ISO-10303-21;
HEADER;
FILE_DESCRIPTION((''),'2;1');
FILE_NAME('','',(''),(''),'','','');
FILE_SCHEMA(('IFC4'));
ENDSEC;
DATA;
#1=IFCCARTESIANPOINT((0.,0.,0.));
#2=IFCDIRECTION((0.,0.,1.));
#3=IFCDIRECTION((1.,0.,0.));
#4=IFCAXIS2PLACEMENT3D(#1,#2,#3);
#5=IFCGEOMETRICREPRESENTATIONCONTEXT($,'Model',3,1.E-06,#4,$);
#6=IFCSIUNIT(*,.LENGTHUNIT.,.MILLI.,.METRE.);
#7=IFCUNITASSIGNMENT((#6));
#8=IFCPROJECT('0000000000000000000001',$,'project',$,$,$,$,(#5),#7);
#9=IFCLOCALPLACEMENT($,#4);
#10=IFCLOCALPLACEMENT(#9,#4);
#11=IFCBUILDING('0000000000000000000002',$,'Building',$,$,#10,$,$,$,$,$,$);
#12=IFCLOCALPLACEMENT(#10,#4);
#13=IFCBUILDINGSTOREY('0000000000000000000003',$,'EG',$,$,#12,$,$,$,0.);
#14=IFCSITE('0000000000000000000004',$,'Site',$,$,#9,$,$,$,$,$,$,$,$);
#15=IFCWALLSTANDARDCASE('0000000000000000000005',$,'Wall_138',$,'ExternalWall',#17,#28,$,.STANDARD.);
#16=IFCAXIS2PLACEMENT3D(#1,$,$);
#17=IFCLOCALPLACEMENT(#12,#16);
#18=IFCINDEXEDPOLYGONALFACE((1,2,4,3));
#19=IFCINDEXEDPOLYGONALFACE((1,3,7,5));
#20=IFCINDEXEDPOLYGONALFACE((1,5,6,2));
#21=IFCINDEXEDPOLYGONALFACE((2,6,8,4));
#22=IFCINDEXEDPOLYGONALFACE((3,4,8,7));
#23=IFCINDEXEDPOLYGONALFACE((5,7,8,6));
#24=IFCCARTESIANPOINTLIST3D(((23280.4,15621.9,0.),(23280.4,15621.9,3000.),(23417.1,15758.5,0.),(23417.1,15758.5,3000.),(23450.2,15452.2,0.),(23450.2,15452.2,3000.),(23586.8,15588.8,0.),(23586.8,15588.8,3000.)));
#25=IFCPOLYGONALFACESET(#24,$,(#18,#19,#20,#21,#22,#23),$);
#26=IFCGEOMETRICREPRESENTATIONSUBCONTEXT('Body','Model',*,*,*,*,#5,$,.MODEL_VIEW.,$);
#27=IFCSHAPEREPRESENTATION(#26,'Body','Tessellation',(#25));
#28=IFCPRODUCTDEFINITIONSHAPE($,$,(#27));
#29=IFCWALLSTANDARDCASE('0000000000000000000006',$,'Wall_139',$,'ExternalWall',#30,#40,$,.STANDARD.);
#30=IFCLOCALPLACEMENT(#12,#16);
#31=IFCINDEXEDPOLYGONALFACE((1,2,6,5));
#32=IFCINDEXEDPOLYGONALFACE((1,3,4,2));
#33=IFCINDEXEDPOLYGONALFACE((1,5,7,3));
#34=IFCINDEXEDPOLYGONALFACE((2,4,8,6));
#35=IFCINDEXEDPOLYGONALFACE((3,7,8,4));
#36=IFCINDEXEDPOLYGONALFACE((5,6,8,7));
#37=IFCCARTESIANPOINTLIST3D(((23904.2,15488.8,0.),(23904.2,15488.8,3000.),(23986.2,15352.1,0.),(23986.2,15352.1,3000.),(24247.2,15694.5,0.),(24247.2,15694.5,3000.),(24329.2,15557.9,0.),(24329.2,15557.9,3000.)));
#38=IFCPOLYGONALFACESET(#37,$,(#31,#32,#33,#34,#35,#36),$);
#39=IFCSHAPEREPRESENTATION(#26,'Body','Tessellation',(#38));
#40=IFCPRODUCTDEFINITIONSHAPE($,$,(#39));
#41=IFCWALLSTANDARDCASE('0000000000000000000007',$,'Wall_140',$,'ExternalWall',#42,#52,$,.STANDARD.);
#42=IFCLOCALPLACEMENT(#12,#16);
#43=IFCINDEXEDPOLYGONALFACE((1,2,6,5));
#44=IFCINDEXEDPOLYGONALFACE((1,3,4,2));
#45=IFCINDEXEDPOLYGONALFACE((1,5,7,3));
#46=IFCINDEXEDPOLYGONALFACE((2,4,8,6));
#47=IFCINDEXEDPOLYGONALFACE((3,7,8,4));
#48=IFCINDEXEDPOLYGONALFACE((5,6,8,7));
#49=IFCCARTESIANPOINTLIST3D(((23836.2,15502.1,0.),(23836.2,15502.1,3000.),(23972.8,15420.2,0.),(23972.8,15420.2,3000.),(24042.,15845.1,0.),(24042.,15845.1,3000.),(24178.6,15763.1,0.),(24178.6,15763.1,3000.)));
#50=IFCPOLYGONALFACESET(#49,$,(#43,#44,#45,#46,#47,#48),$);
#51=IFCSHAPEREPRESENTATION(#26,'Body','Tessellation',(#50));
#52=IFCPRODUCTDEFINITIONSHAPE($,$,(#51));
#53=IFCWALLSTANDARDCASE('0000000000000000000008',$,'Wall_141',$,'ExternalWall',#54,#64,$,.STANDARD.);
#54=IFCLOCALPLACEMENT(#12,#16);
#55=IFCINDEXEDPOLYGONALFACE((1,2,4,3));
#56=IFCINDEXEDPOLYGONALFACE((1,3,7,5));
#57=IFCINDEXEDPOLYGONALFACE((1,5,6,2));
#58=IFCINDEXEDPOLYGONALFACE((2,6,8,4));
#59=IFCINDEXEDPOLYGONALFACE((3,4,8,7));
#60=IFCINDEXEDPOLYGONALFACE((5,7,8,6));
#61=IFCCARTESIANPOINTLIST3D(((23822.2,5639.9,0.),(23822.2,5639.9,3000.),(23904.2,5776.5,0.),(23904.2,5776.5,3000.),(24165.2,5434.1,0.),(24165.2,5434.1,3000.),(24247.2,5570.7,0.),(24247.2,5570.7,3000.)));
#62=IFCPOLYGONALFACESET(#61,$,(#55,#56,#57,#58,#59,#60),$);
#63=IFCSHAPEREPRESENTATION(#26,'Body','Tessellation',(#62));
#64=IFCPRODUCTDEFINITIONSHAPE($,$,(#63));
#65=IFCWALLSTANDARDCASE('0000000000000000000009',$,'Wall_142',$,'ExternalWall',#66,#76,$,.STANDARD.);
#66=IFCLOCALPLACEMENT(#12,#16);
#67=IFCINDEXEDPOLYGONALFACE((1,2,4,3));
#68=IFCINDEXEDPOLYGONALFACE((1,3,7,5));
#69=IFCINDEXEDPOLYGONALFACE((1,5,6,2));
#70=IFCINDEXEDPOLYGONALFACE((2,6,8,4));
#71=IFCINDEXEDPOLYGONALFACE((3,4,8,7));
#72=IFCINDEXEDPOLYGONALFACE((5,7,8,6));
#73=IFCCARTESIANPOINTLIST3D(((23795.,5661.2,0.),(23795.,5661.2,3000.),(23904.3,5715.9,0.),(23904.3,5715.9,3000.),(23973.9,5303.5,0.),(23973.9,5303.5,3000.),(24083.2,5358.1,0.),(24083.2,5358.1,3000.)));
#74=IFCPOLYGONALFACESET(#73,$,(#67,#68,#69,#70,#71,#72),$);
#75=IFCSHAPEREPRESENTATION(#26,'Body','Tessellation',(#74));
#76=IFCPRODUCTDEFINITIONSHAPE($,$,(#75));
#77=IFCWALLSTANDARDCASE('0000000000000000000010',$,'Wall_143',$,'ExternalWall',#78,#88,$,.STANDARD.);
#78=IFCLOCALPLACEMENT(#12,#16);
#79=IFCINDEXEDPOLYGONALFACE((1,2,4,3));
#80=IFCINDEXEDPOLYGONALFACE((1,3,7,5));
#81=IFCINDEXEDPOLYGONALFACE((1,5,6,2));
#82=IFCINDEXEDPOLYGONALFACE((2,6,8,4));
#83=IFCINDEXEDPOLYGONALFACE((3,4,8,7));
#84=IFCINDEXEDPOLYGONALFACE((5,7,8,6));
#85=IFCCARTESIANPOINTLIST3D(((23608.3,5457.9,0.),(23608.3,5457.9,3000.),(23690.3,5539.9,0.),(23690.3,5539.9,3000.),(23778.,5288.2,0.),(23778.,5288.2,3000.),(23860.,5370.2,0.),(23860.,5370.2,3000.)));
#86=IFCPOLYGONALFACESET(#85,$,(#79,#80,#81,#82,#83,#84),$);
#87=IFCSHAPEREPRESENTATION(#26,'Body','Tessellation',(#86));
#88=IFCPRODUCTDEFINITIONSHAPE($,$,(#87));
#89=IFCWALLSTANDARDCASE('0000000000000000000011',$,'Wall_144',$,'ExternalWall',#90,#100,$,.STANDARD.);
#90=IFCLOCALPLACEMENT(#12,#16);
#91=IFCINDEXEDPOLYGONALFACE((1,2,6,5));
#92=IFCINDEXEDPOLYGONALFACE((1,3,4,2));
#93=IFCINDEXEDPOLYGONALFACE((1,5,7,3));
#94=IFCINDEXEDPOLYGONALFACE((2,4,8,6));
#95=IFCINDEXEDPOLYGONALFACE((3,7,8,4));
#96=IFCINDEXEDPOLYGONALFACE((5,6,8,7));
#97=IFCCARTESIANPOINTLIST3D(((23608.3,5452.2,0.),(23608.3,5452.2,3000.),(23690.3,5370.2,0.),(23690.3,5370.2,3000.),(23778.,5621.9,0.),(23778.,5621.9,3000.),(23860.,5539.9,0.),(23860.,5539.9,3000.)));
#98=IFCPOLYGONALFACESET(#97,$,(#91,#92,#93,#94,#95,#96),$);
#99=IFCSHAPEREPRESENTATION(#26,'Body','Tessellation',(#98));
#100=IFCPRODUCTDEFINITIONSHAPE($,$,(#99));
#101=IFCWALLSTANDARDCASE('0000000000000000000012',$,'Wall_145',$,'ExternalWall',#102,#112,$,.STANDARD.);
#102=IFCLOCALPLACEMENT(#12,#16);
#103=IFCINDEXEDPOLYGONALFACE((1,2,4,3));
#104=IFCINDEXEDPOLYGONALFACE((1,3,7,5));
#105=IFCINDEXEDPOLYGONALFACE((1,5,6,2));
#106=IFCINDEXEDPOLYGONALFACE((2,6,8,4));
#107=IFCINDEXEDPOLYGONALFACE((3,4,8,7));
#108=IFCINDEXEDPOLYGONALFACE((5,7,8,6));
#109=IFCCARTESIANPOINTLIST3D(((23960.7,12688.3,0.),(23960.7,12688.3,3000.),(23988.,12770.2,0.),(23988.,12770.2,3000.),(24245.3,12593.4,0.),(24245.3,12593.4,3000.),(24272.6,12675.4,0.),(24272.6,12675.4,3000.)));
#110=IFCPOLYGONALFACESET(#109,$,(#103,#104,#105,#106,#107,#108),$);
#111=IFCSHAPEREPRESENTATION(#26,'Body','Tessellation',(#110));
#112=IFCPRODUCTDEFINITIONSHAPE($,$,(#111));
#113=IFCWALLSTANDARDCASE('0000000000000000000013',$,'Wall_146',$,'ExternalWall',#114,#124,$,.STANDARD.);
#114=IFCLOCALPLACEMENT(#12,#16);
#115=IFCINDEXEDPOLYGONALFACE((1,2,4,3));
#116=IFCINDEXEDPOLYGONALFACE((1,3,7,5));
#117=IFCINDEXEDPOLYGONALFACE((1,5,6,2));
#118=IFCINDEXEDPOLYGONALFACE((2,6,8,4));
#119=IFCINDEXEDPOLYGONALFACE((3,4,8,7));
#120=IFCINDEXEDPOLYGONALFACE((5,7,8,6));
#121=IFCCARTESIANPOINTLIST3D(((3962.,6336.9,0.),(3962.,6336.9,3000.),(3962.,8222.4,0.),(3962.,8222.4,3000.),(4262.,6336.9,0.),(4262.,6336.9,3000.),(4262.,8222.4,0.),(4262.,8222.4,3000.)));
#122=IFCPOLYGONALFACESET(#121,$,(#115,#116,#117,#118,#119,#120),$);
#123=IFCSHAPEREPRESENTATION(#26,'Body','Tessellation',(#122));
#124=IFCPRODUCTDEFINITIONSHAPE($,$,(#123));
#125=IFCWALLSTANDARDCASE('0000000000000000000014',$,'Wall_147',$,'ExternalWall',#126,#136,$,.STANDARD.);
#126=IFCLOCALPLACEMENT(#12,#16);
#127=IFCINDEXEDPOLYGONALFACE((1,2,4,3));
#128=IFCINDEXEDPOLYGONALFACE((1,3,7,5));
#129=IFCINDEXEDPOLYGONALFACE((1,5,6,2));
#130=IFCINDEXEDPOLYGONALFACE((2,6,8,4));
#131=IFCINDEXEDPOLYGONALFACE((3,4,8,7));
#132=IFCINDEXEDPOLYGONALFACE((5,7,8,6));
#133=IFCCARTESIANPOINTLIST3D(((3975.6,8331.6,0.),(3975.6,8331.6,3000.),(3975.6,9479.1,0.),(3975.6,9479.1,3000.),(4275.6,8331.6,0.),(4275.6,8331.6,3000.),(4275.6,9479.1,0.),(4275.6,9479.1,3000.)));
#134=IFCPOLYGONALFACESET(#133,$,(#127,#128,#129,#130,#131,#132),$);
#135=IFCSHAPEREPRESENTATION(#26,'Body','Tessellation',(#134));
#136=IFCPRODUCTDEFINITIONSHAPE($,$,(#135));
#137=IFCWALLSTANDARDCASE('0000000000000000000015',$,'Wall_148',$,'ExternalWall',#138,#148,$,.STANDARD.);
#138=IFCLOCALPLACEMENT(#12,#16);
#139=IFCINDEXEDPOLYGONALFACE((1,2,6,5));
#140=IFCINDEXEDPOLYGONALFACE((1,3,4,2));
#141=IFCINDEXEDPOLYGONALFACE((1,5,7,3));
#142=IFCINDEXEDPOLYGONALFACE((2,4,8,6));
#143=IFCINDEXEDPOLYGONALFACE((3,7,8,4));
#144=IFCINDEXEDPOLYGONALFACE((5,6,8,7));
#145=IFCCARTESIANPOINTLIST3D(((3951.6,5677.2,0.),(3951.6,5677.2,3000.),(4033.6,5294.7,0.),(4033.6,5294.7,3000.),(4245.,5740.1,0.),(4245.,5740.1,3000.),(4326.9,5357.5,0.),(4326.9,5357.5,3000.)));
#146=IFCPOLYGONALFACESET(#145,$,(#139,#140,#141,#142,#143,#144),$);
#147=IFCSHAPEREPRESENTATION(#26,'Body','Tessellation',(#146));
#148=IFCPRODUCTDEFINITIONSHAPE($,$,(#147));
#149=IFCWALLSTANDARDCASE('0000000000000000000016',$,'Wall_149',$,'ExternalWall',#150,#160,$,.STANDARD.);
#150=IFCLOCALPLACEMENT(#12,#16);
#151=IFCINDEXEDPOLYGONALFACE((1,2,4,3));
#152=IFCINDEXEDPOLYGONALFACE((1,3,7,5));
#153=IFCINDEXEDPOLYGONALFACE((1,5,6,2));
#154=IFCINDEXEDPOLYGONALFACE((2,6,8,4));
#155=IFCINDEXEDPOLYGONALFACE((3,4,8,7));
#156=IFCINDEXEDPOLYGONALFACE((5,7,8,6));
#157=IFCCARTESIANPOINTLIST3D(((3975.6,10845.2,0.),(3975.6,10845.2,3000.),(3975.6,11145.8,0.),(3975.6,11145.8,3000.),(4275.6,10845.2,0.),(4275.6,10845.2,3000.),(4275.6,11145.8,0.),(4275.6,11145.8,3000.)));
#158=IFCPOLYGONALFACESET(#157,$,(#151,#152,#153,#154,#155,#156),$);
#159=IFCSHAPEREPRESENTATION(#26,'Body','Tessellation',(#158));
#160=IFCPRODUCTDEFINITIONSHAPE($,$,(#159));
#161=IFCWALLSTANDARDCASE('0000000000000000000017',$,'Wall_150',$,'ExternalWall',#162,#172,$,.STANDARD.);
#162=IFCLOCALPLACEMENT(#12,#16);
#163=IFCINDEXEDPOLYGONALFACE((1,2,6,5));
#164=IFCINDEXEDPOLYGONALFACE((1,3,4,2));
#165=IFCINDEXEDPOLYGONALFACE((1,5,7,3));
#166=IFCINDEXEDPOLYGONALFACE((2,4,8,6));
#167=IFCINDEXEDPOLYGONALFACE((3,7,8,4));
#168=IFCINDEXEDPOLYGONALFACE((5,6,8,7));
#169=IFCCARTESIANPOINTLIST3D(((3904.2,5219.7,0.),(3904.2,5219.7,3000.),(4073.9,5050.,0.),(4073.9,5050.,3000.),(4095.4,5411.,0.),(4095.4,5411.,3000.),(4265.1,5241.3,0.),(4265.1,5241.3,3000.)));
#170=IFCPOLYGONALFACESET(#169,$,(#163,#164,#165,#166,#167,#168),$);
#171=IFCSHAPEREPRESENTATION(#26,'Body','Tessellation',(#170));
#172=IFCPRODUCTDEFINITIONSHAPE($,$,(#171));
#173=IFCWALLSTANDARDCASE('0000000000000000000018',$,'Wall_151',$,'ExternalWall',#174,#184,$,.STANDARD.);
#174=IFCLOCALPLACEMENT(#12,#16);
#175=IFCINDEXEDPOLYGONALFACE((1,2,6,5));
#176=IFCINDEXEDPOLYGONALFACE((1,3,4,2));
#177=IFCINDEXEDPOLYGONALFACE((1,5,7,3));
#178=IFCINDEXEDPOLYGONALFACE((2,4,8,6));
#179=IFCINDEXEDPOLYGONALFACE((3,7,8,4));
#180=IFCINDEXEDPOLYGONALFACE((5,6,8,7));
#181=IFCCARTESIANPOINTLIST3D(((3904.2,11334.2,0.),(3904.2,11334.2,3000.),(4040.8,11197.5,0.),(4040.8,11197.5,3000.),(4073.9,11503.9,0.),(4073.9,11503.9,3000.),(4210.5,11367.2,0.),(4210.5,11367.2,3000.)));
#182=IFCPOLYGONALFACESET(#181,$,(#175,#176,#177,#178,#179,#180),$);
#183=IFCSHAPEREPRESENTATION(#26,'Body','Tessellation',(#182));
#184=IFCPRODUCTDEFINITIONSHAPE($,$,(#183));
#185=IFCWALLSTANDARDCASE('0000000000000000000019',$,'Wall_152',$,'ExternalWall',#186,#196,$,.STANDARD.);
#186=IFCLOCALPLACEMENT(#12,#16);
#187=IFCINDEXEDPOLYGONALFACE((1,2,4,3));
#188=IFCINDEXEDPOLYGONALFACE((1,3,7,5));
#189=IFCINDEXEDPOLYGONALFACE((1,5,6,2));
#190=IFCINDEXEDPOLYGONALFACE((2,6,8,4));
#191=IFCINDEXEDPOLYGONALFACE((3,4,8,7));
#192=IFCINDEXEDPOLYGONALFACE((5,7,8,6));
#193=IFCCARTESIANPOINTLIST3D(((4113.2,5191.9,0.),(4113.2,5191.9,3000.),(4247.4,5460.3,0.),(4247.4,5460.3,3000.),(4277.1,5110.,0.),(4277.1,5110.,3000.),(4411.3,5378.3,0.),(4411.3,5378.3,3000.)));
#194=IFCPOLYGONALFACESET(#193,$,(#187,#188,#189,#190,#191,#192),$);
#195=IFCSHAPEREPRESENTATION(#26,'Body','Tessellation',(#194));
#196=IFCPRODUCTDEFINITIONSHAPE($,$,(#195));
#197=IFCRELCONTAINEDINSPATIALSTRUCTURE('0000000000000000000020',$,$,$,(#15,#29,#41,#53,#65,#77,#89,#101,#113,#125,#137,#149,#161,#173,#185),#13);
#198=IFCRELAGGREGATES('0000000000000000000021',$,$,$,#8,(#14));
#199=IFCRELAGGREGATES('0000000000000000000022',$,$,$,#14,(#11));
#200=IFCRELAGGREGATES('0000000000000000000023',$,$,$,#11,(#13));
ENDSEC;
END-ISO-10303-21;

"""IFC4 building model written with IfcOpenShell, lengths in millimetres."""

from ifc_helpers import new_model, si_unit, frame, origin_with_axes, place, context, subcontext, project, spatial, rectangle, extrude, element, save


model = new_model("IFC4")

# Units and contexts
model_context = context("Model", 3, precision=1e-06, world=origin_with_axes())
body_context = subcontext(model_context, "Body", "Model", "MODEL_VIEW")
ifc_project = project(units=[si_unit("LENGTHUNIT", "METRE", prefix="MILLI")], contexts=[model_context])

# Site, building, storey
site_placement = place(None, origin_with_axes())
site = spatial("IfcSite", under=ifc_project, at=site_placement, Name="Site")
building_placement = place(site_placement, origin_with_axes())
building = spatial("IfcBuilding", under=site, at=building_placement, Name="Building")
storey_placement = place(building_placement, origin_with_axes())
storey = spatial("IfcBuildingStorey", under=building, at=storey_placement, Name="EG", Elevation=0.0)

# Walls
wall_1_placement = place(storey_placement, origin_with_axes())
element("IfcWallStandardCase", 1, at=wall_1_placement, inside=storey, Name="Wall_138", ObjectType="ExternalWall", PredefinedType="STANDARD", context=body_context, shape_type="SweptSolid", body=[
    extrude(rectangle(XDim=193.2, YDim=240.0), frame((23433.6, 15605.3, 0.0), z_axis=(0.0, 0.0, 1.0), x_axis=(-0.707107, -0.707107, 0.0)), (0.0, 0.0, 1.0), 3000.0),
])
wall_2_placement = place(storey_placement, origin_with_axes())
element("IfcWallStandardCase", 2, at=wall_2_placement, inside=storey, Name="Wall_139", ObjectType="ExternalWall", PredefinedType="STANDARD", context=body_context, shape_type="SweptSolid", body=[
    extrude(rectangle(XDim=159.3, YDim=400.0), frame((24116.7, 15523.3, 0.0), z_axis=(0.0, 0.0, 1.0), x_axis=(-0.514496, 0.857493, 0.0)), (0.0, 0.0, 1.0), 3000.0),
])
wall_3_placement = place(storey_placement, origin_with_axes())
element("IfcWallStandardCase", 3, at=wall_3_placement, inside=storey, Name="Wall_140", ObjectType="ExternalWall", PredefinedType="STANDARD", context=body_context, shape_type="SweptSolid", body=[
    extrude(rectangle(XDim=159.3, YDim=400.0), frame((24007.4, 15632.6, 0.0), z_axis=(0.0, 0.0, 1.0), x_axis=(-0.857493, 0.514496, 0.0)), (0.0, 0.0, 1.0), 3000.0),
])
wall_4_placement = place(storey_placement, origin_with_axes())
element("IfcWallStandardCase", 4, at=wall_4_placement, inside=storey, Name="Wall_141", ObjectType="ExternalWall", PredefinedType="STANDARD", context=body_context, shape_type="SweptSolid", body=[
    extrude(rectangle(XDim=159.3, YDim=400.0), frame((24034.7, 5605.3, 0.0), z_axis=(0.0, 0.0, 1.0), x_axis=(-0.514496, -0.857493, 0.0)), (0.0, 0.0, 1.0), 3000.0),
])
wall_5_placement = place(storey_placement, origin_with_axes())
element("IfcWallStandardCase", 5, at=wall_5_placement, inside=storey, Name="Wall_142", ObjectType="ExternalWall", PredefinedType="STANDARD", context=body_context, shape_type="SweptSolid", body=[
    extrude(rectangle(XDim=122.2, YDim=400.0), frame((23939.1, 5509.7, 0.0), z_axis=(0.0, 0.0, 1.0), x_axis=(-0.894427, -0.447214, 0.0)), (0.0, 0.0, 1.0), 3000.0),
])
wall_6_placement = place(storey_placement, origin_with_axes())
element("IfcWallStandardCase", 6, at=wall_6_placement, inside=storey, Name="Wall_143", ObjectType="ExternalWall", PredefinedType="STANDARD", context=body_context, shape_type="SweptSolid", body=[
    extrude(rectangle(XDim=115.9, YDim=240.0), frame((23734.2, 5414.1, 0.0), z_axis=(0.0, 0.0, 1.0), x_axis=(-0.707107, -0.707107, 0.0)), (0.0, 0.0, 1.0), 3000.0),
])
wall_7_placement = place(storey_placement, origin_with_axes())
element("IfcWallStandardCase", 7, at=wall_7_placement, inside=storey, Name="Wall_144", ObjectType="ExternalWall", PredefinedType="STANDARD", context=body_context, shape_type="SweptSolid", body=[
    extrude(rectangle(XDim=115.9, YDim=240.0), frame((23734.2, 5496.0, 0.0), z_axis=(0.0, 0.0, 1.0), x_axis=(-0.707107, 0.707107, 0.0)), (0.0, 0.0, 1.0), 3000.0),
])
wall_8_placement = place(storey_placement, origin_with_axes())
element("IfcWallStandardCase", 8, at=wall_8_placement, inside=storey, Name="Wall_145", ObjectType="ExternalWall", PredefinedType="STANDARD", context=body_context, shape_type="SweptSolid", body=[
    extrude(rectangle(XDim=86.4, YDim=300.0), frame((24116.7, 12681.8, 0.0), z_axis=(0.0, 0.0, 1.0), x_axis=(0.316228, 0.948683, 0.0)), (0.0, 0.0, 1.0), 3000.0),
])
wall_9_placement = place(storey_placement, origin_with_axes())
element("IfcWallStandardCase", 9, at=wall_9_placement, inside=storey, Name="Wall_146", ObjectType="ExternalWall", PredefinedType="STANDARD", context=body_context, shape_type="SweptSolid", body=[
    extrude(rectangle(XDim=1885.4, YDim=300.0), frame((4112.0, 7279.7, 0.0), z_axis=(0.0, 0.0, 1.0), x_axis=(0.0, 1.0, 0.0)), (0.0, 0.0, 1.0), 3000.0),
])
wall_10_placement = place(storey_placement, origin_with_axes())
element("IfcWallStandardCase", 10, at=wall_10_placement, inside=storey, Name="Wall_147", ObjectType="ExternalWall", PredefinedType="STANDARD", context=body_context, shape_type="SweptSolid", body=[
    extrude(rectangle(XDim=1147.5, YDim=300.0), frame((4125.6, 8905.3, 0.0), z_axis=(0.0, 0.0, 1.0), x_axis=(0.0, 1.0, 0.0)), (0.0, 0.0, 1.0), 3000.0),
])
wall_11_placement = place(storey_placement, origin_with_axes())
element("IfcWallStandardCase", 11, at=wall_11_placement, inside=storey, Name="Wall_148", ObjectType="ExternalWall", PredefinedType="STANDARD", context=body_context, shape_type="SweptSolid", body=[
    extrude(rectangle(XDim=391.2, YDim=300.0), frame((4139.3, 5517.4, 0.0), z_axis=(0.0, 0.0, 1.0), x_axis=(-0.209529, 0.977802, 0.0)), (0.0, 0.0, 1.0), 3000.0),
])
wall_12_placement = place(storey_placement, origin_with_axes())
element("IfcWallStandardCase", 12, at=wall_12_placement, inside=storey, Name="Wall_149", ObjectType="ExternalWall", PredefinedType="STANDARD", context=body_context, shape_type="SweptSolid", body=[
    extrude(rectangle(XDim=300.5, YDim=300.0), frame((4125.6, 10995.5, 0.0), z_axis=(0.0, 0.0, 1.0), x_axis=(0.0, 1.0, 0.0)), (0.0, 0.0, 1.0), 3000.0),
])
wall_13_placement = place(storey_placement, origin_with_axes())
element("IfcWallStandardCase", 13, at=wall_13_placement, inside=storey, Name="Wall_150", ObjectType="ExternalWall", PredefinedType="STANDARD", context=body_context, shape_type="SweptSolid", body=[
    extrude(rectangle(XDim=270.5, YDim=240.0), frame((4084.6, 5230.5, 0.0), z_axis=(0.0, 0.0, 1.0), x_axis=(-0.707107, -0.707107, 0.0)), (0.0, 0.0, 1.0), 3000.0),
])
wall_14_placement = place(storey_placement, origin_with_axes())
element("IfcWallStandardCase", 14, at=wall_14_placement, inside=storey, Name="Wall_151", ObjectType="ExternalWall", PredefinedType="STANDARD", context=body_context, shape_type="SweptSolid", body=[
    extrude(rectangle(XDim=193.2, YDim=240.0), frame((4057.3, 11350.7, 0.0), z_axis=(0.0, 0.0, 1.0), x_axis=(-0.707107, 0.707107, 0.0)), (0.0, 0.0, 1.0), 3000.0),
])
wall_15_placement = place(storey_placement, origin_with_axes())
element("IfcWallStandardCase", 15, at=wall_15_placement, inside=storey, Name="Wall_152", ObjectType="ExternalWall", PredefinedType="STANDARD", context=body_context, shape_type="SweptSolid", body=[
    extrude(rectangle(XDim=183.3, YDim=300.0), frame((4262.2, 5285.1, 0.0), z_axis=(0.0, 0.0, 1.0), x_axis=(-0.894427, 0.447214, 0.0)), (0.0, 0.0, 1.0), 3000.0),
])

save(model, "model.ifc")
